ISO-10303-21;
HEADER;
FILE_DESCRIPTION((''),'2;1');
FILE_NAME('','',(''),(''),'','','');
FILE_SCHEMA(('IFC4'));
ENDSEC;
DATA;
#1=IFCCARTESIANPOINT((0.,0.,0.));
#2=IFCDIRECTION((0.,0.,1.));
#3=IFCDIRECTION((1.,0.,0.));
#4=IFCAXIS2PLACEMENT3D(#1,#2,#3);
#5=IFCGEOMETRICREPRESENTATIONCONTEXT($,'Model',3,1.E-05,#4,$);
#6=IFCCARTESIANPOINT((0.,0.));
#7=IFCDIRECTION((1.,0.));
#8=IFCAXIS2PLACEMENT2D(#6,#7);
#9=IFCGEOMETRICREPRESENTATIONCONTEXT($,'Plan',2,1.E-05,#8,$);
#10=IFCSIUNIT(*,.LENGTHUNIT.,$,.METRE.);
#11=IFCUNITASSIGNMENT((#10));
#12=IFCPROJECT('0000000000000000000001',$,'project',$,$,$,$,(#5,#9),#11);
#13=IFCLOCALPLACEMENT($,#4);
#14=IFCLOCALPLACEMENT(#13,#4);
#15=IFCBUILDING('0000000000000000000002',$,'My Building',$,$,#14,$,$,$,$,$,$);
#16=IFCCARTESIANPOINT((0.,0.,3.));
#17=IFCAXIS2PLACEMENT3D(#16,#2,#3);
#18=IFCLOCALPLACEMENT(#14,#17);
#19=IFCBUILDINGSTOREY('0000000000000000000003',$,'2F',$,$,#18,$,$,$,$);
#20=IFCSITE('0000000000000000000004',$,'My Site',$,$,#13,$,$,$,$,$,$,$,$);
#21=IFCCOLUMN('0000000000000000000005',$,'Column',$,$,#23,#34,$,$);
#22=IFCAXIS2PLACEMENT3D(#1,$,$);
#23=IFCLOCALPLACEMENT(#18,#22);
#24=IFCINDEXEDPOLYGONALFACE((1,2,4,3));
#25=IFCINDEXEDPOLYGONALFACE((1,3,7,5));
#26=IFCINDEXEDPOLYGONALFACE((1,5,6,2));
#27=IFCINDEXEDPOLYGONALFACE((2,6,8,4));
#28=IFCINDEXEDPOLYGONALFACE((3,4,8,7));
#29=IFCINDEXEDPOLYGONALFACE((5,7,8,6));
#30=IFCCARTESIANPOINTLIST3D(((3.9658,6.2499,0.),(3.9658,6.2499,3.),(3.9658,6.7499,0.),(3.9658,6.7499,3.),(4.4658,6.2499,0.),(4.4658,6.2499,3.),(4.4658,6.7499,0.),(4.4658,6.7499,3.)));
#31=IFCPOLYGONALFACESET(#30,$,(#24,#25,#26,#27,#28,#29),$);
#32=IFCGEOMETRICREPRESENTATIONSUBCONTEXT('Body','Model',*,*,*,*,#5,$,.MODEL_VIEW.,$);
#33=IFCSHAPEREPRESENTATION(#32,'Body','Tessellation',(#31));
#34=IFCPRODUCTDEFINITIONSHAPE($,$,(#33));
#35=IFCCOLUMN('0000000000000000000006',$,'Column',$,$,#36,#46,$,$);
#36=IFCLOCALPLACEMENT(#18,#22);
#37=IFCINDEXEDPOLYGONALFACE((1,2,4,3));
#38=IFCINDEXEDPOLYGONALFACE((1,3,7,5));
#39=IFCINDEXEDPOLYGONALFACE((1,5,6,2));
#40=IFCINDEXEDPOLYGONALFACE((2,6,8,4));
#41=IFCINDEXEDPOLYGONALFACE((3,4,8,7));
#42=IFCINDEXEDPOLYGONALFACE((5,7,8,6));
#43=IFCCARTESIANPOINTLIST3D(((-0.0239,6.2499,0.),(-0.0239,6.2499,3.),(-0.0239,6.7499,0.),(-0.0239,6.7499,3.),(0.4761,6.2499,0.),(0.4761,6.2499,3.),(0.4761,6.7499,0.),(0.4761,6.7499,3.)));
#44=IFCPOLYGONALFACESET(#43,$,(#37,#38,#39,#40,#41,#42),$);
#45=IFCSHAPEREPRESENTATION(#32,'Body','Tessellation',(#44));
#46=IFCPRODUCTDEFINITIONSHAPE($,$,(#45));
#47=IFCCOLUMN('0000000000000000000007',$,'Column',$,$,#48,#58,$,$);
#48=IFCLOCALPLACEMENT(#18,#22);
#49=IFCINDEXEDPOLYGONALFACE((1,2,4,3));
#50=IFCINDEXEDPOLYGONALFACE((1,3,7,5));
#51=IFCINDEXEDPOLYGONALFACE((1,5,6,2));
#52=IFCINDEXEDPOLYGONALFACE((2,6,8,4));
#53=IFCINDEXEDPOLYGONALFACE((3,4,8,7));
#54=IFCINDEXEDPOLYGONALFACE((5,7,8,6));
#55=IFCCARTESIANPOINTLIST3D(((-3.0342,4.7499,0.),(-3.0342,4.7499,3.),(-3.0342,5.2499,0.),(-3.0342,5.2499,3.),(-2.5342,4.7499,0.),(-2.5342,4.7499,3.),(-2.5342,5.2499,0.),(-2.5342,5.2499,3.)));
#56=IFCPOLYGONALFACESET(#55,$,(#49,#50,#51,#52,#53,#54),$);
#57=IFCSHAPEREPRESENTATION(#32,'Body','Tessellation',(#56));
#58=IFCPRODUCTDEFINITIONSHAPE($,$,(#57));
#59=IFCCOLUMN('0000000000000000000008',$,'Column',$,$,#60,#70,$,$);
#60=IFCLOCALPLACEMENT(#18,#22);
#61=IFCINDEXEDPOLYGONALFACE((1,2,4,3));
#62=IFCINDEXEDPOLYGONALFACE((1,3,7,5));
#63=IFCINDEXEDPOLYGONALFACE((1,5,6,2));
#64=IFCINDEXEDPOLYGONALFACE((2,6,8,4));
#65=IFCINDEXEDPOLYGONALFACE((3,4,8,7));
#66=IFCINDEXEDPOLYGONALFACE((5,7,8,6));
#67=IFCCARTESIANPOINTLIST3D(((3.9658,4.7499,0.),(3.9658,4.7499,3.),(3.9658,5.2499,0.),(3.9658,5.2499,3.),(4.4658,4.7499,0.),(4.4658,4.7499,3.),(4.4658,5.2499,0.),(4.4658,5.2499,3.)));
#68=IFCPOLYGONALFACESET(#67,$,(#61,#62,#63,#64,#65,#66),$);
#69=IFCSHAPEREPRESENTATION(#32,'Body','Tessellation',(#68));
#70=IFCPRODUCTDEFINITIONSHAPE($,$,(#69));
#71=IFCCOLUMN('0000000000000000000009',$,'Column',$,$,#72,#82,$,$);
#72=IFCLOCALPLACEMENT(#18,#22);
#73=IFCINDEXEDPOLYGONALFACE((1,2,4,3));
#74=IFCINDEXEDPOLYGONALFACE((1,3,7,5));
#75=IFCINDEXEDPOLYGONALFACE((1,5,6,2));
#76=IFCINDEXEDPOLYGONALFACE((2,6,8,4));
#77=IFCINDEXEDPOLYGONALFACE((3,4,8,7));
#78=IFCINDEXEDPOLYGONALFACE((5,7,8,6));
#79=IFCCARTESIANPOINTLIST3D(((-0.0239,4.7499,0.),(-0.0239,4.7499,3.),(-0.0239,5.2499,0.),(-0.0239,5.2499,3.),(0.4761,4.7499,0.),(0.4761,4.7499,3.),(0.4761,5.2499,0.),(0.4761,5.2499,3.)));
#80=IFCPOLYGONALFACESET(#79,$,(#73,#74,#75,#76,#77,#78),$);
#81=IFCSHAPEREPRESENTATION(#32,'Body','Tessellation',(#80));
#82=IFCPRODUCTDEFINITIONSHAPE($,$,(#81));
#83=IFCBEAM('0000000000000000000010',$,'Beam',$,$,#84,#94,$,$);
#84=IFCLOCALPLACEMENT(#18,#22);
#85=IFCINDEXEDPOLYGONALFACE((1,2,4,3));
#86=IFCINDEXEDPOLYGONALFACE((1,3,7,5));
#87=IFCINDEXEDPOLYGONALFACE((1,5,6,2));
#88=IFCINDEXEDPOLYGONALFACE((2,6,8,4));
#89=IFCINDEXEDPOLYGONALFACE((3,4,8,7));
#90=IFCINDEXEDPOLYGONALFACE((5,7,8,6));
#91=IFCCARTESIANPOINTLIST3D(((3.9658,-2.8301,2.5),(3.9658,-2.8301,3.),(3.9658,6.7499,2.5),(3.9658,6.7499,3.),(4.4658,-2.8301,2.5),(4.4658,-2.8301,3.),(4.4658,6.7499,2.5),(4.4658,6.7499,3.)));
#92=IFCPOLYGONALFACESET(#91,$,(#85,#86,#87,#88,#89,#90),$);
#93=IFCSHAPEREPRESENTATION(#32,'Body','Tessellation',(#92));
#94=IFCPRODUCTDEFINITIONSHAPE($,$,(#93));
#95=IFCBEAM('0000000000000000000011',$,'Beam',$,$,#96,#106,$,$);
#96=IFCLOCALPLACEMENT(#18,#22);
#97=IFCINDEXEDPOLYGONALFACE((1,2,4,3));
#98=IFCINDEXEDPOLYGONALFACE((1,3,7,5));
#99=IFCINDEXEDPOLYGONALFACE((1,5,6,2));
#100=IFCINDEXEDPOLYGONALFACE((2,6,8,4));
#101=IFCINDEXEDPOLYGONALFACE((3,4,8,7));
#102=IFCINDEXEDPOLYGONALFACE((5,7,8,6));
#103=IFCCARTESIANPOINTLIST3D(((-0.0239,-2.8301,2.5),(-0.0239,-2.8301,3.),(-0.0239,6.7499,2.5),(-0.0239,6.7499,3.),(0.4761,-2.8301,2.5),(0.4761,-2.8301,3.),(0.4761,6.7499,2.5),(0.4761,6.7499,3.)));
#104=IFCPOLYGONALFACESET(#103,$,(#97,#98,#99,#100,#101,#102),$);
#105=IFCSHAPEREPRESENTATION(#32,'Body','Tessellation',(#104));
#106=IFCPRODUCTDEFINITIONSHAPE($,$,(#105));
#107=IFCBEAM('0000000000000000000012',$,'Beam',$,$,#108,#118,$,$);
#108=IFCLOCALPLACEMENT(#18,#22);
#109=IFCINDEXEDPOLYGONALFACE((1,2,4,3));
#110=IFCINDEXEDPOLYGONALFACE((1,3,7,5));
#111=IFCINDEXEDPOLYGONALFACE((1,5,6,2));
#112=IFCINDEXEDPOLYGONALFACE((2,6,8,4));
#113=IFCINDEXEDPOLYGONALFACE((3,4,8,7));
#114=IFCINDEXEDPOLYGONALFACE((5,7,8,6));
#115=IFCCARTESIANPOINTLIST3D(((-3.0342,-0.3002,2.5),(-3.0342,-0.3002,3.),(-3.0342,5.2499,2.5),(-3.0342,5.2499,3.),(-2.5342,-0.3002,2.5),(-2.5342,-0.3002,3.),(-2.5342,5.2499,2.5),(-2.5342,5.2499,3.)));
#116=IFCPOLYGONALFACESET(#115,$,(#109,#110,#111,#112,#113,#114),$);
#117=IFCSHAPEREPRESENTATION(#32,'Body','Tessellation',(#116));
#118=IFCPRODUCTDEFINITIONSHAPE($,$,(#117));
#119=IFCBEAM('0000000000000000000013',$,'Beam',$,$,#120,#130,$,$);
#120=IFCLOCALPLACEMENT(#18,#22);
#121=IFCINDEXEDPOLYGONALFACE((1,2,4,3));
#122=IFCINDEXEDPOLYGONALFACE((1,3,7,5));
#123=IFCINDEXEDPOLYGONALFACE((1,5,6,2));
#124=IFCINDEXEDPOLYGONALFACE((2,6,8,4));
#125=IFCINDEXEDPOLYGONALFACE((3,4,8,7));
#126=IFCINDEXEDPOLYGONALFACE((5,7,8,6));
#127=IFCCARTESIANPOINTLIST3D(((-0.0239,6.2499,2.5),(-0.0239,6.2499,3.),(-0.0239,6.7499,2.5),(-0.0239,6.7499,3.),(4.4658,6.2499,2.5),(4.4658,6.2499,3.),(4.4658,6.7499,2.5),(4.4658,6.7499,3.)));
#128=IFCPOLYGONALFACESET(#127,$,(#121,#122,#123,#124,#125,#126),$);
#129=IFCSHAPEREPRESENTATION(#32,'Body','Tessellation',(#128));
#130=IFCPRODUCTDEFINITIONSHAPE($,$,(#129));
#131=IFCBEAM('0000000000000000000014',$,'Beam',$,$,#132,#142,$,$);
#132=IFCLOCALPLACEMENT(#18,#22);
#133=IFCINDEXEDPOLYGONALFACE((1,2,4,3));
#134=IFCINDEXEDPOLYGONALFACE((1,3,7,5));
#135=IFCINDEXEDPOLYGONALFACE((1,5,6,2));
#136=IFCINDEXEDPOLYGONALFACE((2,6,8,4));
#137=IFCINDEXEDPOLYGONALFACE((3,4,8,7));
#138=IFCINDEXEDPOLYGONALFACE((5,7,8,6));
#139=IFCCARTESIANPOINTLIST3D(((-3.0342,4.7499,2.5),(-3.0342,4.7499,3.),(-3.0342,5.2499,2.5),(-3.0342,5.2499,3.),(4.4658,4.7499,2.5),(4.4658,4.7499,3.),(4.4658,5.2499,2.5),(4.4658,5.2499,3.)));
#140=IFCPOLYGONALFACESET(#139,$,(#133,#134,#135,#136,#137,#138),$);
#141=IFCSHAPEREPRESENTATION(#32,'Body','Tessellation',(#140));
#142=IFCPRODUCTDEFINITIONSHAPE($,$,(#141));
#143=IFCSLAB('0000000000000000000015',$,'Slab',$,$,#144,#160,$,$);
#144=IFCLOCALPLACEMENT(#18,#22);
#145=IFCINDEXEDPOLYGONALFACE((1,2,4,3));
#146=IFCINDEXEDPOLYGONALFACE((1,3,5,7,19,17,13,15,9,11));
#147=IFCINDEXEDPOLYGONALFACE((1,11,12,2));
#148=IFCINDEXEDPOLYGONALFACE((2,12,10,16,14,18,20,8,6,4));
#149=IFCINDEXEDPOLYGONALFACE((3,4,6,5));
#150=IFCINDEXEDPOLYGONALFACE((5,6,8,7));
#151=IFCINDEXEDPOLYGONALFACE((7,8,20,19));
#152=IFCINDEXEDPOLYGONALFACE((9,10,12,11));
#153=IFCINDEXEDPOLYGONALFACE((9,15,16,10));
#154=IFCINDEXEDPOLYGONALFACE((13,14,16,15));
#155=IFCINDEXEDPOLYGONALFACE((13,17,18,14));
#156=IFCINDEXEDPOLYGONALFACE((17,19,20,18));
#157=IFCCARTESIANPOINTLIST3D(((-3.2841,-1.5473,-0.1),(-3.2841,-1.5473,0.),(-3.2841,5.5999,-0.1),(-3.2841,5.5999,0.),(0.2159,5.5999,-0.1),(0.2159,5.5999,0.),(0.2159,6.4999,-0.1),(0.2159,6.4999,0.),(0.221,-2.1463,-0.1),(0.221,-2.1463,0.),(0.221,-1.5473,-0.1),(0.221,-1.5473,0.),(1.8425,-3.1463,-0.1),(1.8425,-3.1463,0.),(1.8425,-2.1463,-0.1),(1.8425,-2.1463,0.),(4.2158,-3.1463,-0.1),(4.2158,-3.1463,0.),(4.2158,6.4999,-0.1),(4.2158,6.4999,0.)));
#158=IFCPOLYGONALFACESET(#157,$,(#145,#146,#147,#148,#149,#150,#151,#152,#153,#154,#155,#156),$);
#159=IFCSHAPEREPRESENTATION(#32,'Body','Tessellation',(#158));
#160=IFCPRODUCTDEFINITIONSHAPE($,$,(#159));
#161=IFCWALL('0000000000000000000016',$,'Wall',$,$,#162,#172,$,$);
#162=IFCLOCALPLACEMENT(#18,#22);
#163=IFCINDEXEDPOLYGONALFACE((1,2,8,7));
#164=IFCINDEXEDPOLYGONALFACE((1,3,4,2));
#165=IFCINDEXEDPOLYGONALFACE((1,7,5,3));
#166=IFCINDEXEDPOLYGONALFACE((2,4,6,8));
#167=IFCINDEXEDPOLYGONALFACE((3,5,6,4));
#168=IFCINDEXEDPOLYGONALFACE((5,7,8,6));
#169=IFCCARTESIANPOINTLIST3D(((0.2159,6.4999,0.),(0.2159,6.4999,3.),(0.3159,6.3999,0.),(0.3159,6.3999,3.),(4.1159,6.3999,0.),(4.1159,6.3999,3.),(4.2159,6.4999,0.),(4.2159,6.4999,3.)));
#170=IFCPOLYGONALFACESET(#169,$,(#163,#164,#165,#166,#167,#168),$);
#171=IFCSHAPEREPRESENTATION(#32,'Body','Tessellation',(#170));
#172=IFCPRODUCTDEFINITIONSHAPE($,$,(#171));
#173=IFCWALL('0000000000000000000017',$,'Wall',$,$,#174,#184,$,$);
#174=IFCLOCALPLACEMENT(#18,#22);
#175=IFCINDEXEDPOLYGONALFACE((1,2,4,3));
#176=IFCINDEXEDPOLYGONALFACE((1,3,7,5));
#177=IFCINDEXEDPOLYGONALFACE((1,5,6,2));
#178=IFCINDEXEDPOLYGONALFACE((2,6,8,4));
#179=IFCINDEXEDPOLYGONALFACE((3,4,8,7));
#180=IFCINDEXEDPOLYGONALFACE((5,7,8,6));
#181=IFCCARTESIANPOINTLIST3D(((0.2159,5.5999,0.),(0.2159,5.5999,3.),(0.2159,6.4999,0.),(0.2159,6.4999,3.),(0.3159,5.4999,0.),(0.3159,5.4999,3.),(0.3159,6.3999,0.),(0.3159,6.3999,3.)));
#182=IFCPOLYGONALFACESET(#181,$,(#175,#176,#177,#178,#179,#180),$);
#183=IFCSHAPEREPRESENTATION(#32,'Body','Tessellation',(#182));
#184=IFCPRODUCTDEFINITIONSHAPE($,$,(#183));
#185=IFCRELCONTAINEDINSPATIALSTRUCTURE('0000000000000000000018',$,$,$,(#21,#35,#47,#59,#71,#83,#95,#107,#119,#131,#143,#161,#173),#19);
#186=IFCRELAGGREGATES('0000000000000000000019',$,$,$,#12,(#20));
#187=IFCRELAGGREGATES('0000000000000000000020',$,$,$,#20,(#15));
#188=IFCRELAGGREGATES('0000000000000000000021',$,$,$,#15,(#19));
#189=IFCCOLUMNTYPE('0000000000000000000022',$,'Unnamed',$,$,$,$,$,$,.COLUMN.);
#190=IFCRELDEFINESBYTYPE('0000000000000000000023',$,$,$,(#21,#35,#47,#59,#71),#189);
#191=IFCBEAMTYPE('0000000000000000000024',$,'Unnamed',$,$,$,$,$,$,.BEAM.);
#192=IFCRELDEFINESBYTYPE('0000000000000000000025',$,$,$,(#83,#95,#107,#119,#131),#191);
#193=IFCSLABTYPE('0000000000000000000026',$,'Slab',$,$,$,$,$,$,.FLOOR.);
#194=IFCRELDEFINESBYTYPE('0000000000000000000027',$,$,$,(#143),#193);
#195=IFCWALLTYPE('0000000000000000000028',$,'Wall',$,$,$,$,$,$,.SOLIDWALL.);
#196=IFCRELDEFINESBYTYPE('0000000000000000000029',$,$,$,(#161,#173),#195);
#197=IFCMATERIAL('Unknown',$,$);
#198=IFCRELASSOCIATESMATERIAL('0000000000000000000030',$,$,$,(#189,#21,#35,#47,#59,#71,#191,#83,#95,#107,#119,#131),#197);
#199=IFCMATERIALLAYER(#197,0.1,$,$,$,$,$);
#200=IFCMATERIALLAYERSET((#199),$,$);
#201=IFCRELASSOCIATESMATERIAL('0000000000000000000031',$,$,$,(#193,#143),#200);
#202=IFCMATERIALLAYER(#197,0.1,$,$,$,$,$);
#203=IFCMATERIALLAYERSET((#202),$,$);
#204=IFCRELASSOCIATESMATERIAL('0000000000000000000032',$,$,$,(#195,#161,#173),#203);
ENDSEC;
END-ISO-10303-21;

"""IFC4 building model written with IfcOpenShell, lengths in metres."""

from ifc_helpers import new_model, si_unit, frame, origin_with_axes, origin_2d_with_axis, place, context, subcontext, project, spatial, line, indexed_curve, rectangle, outline, extrude, material, layer, layer_set, layer_usage, material_profile, profile_set, profile_usage, type_object, element, save


model = new_model("IFC4")

# Units and contexts
model_context = context("Model", 3, precision=1e-05, world=origin_with_axes())
plan_context = context("Plan", 2, precision=1e-05, world=origin_2d_with_axis())
body_context_1 = subcontext(model_context, "Body", "Model", "MODEL_VIEW")
ifc_project = project(units=[si_unit("LENGTHUNIT", "METRE")], contexts=[model_context, plan_context])

# Site, building, storey
site_placement = place(None, origin_with_axes())
site = spatial("IfcSite", under=ifc_project, at=site_placement, Name="My Site")
building_placement = place(site_placement, origin_with_axes())
building = spatial("IfcBuilding", under=site, at=building_placement, Name="My Building")
storey_placement = place(building_placement, frame((0.0, 0.0, 3.0), z_axis=(0.0, 0.0, 1.0), x_axis=(1.0, 0.0, 0.0)))
storey = spatial("IfcBuildingStorey", under=building, at=storey_placement, Name="2F")

# Columns
ifc_material = material(Name="Unknown")
ifc_material_profile_1 = material_profile(ifc_material, rectangle(XDim=0.5, YDim=0.5))
ifc_profile_set_1 = profile_set([ifc_material_profile_1])
ifc_profile_usage_1 = profile_usage(ifc_profile_set_1, cardinal=1)
column_type = type_object("IfcColumnType", Name="Unnamed", PredefinedType="COLUMN", material=ifc_profile_set_1)
column_1_placement = place(storey_placement, frame((4.4658, 6.2499, 0.0), z_axis=(0.0, 0.0, 1.0), x_axis=(1.0, 0.0, 0.0)))
element("IfcColumn", 1, at=column_1_placement, inside=storey, type_object=column_type, material=ifc_profile_usage_1, Name="Column", context=body_context_1, shape_type="SweptSolid", body=[
    extrude(rectangle(XDim=0.5, YDim=0.5), frame((-0.25, 0.25, 0.0), z_axis=(0.0, 0.0, 1.0), x_axis=(1.0, 0.0, 0.0)), (0.0, 0.0, 1.0), 3.0),
])
ifc_profile_usage_2 = profile_usage(ifc_profile_set_1, cardinal=1)
column_2_placement = place(storey_placement, frame((0.4761, 6.2499, 0.0), z_axis=(0.0, 0.0, 1.0), x_axis=(1.0, 0.0, 0.0)))
element("IfcColumn", 2, at=column_2_placement, inside=storey, type_object=column_type, material=ifc_profile_usage_2, Name="Column", context=body_context_1, shape_type="SweptSolid", body=[
    extrude(rectangle(XDim=0.5, YDim=0.5), frame((-0.25, 0.25, 0.0), z_axis=(0.0, 0.0, 1.0), x_axis=(1.0, 0.0, 0.0)), (0.0, 0.0, 1.0), 3.0),
])
ifc_profile_usage_3 = profile_usage(ifc_profile_set_1, cardinal=1)
column_3_placement = place(storey_placement, frame((-2.5342, 4.7499, 0.0), z_axis=(0.0, 0.0, 1.0), x_axis=(1.0, 0.0, 0.0)))
element("IfcColumn", 3, at=column_3_placement, inside=storey, type_object=column_type, material=ifc_profile_usage_3, Name="Column", context=body_context_1, shape_type="SweptSolid", body=[
    extrude(rectangle(XDim=0.5, YDim=0.5), frame((-0.25, 0.25, 0.0), z_axis=(0.0, 0.0, 1.0), x_axis=(1.0, 0.0, 0.0)), (0.0, 0.0, 1.0), 3.0),
])
ifc_profile_usage_4 = profile_usage(ifc_profile_set_1, cardinal=1)
column_4_placement = place(storey_placement, frame((4.4658, 4.7499, 0.0), z_axis=(0.0, 0.0, 1.0), x_axis=(1.0, 0.0, 0.0)))
element("IfcColumn", 4, at=column_4_placement, inside=storey, type_object=column_type, material=ifc_profile_usage_4, Name="Column", context=body_context_1, shape_type="SweptSolid", body=[
    extrude(rectangle(XDim=0.5, YDim=0.5), frame((-0.25, 0.25, 0.0), z_axis=(0.0, 0.0, 1.0), x_axis=(1.0, 0.0, 0.0)), (0.0, 0.0, 1.0), 3.0),
])
ifc_profile_usage_5 = profile_usage(ifc_profile_set_1, cardinal=1)
column_5_placement = place(storey_placement, frame((0.4761, 4.7499, 0.0), z_axis=(0.0, 0.0, 1.0), x_axis=(1.0, 0.0, 0.0)))
element("IfcColumn", 5, at=column_5_placement, inside=storey, type_object=column_type, material=ifc_profile_usage_5, Name="Column", context=body_context_1, shape_type="SweptSolid", body=[
    extrude(rectangle(XDim=0.5, YDim=0.5), frame((-0.25, 0.25, 0.0), z_axis=(0.0, 0.0, 1.0), x_axis=(1.0, 0.0, 0.0)), (0.0, 0.0, 1.0), 3.0),
])

# Beams
ifc_material_profile_2 = material_profile(ifc_material, rectangle(XDim=0.5, YDim=0.5))
ifc_profile_set_2 = profile_set([ifc_material_profile_2])
ifc_profile_usage_6 = profile_usage(ifc_profile_set_2, cardinal=7)
beam_type = type_object("IfcBeamType", Name="Unnamed", PredefinedType="BEAM", material=ifc_profile_set_2)
beam_1_placement = place(storey_placement, frame((4.4658, 6.7499, 3.0), z_axis=(0.0, -1.0, 0.0), x_axis=(1.0, 0.0, 0.0)))
element("IfcBeam", 6, at=beam_1_placement, inside=storey, type_object=beam_type, material=ifc_profile_usage_6, Name="Beam", context=body_context_1, shape_type="SweptSolid", body=[
    extrude(rectangle(XDim=0.5, YDim=0.5), frame((-0.25, -0.25, 0.0), z_axis=(0.0, 0.0, 1.0), x_axis=(1.0, 0.0, 0.0)), (0.0, 0.0, 1.0), 9.58),
])
ifc_profile_usage_7 = profile_usage(ifc_profile_set_2, cardinal=7)
beam_2_placement = place(storey_placement, frame((0.4761, 6.7499, 3.0), z_axis=(0.0, -1.0, 0.0), x_axis=(1.0, 0.0, 0.0)))
element("IfcBeam", 7, at=beam_2_placement, inside=storey, type_object=beam_type, material=ifc_profile_usage_7, Name="Beam", context=body_context_1, shape_type="SweptSolid", body=[
    extrude(rectangle(XDim=0.5, YDim=0.5), frame((-0.25, -0.25, 0.0), z_axis=(0.0, 0.0, 1.0), x_axis=(1.0, 0.0, 0.0)), (0.0, 0.0, 1.0), 9.58),
])
ifc_profile_usage_8 = profile_usage(ifc_profile_set_2, cardinal=7)
beam_3_placement = place(storey_placement, frame((-2.5342, 5.2499, 3.0), z_axis=(0.0, -1.0, 0.0), x_axis=(1.0, 0.0, 0.0)))
element("IfcBeam", 8, at=beam_3_placement, inside=storey, type_object=beam_type, material=ifc_profile_usage_8, Name="Beam", context=body_context_1, shape_type="SweptSolid", body=[
    extrude(rectangle(XDim=0.5, YDim=0.5), frame((-0.25, -0.25, 0.0), z_axis=(0.0, 0.0, 1.0), x_axis=(1.0, 0.0, 0.0)), (0.0, 0.0, 1.0), 5.55),
])
ifc_profile_usage_9 = profile_usage(ifc_profile_set_2, cardinal=1)
beam_4_placement = place(storey_placement, frame((4.4658, 6.2499, 2.5), z_axis=(-1.0, 0.0, 0.0), x_axis=(0.0, -1.0, 0.0)))
element("IfcBeam", 9, at=beam_4_placement, inside=storey, type_object=beam_type, material=ifc_profile_usage_9, Name="Beam", context=body_context_1, shape_type="SweptSolid", body=[
    extrude(rectangle(XDim=0.5, YDim=0.5), frame((-0.25, 0.25, 0.0), z_axis=(0.0, 0.0, 1.0), x_axis=(1.0, 0.0, 0.0)), (0.0, 0.0, 1.0), 4.4897),
])
ifc_profile_usage_10 = profile_usage(ifc_profile_set_2, cardinal=1)
beam_5_placement = place(storey_placement, frame((4.4658, 4.7499, 2.5), z_axis=(-1.0, 0.0, 0.0), x_axis=(0.0, -1.0, 0.0)))
element("IfcBeam", 10, at=beam_5_placement, inside=storey, type_object=beam_type, material=ifc_profile_usage_10, Name="Beam", context=body_context_1, shape_type="SweptSolid", body=[
    extrude(rectangle(XDim=0.5, YDim=0.5), frame((-0.25, 0.25, 0.0), z_axis=(0.0, 0.0, 1.0), x_axis=(1.0, 0.0, 0.0)), (0.0, 0.0, 1.0), 7.5),
])

# Slab
ifc_layer_1 = layer(ifc_material, 0.1)
ifc_layer_set_1 = layer_set([ifc_layer_1])
ifc_layer_usage_1 = layer_usage(ifc_layer_set_1, "AXIS3", "POSITIVE", -0.1)
slab_type = type_object("IfcSlabType", Name="Slab", PredefinedType="FLOOR", material=ifc_layer_set_1)
slab_placement = place(storey_placement, frame((4.2158, 6.4999, 0.0), z_axis=(0.0, 0.0, 1.0), x_axis=(1.0, 0.0, 0.0)))
element("IfcSlab", 11, at=slab_placement, inside=storey, type_object=slab_type, material=ifc_layer_usage_1, Name="Slab", context=body_context_1, shape_type="SweptSolid", body=[
    extrude(outline(indexed_curve([(0.0, 0.0), (-4.0, 0.0), (-4.0, -0.9), (-7.5, -0.9), (-7.5, -8.0471), (-3.9948, -8.0471), (-3.9948, -8.6461), (-2.3734, -8.6461), (-2.3734, -9.6461), (0.0, -9.6461), (0.0, 0.0)])), frame((0.0, 0.0, -0.1), z_axis=(0.0, 0.0, 1.0), x_axis=(1.0, 0.0, 0.0)), (0.0, 0.0, 1.0), 0.1),
])

# Walls
ifc_layer_2 = layer(ifc_material, 0.1)
ifc_layer_set_2 = layer_set([ifc_layer_2])
ifc_layer_usage_2 = layer_usage(ifc_layer_set_2, "AXIS2", "POSITIVE", 0.0)
wall_type = type_object("IfcWallType", Name="Wall", PredefinedType="SOLIDWALL", material=ifc_layer_set_2)
wall_1_placement = place(storey_placement, frame((4.2159, 6.4999, 0.0), z_axis=(0.0, 0.0, 1.0), x_axis=(-1.0, 0.0, 0.0)))
element("IfcWall", 12, at=wall_1_placement, inside=storey, type_object=wall_type, material=ifc_layer_usage_2, Name="Wall", context=body_context_1, shape_type="SweptSolid", body=[
    extrude(outline(indexed_curve([(0.0, 0.0), (0.1, 0.1), (3.9, 0.1), (4.0, 0.0)], segments=[line(1, 2, 3, 4, 1)])), origin_with_axes(), (0.0, 0.0, 1.0), 3.0),
])
ifc_layer_usage_3 = layer_usage(ifc_layer_set_2, "AXIS2", "POSITIVE", 0.0)
wall_2_placement = place(storey_placement, frame((0.2159, 6.4999, 0.0), z_axis=(0.0, 0.0, 1.0), x_axis=(0.0, -1.0, 0.0)))
element("IfcWall", 13, at=wall_2_placement, inside=storey, type_object=wall_type, material=ifc_layer_usage_3, Name="Wall", context=body_context_1, shape_type="SweptSolid", body=[
    extrude(outline(indexed_curve([(0.0, 0.0), (0.1, 0.1), (1.0, 0.1), (0.9, 0.0)], segments=[line(1, 2, 3, 4, 1)])), origin_with_axes(), (0.0, 0.0, 1.0), 3.0),
])

save(model, "model.ifc")
